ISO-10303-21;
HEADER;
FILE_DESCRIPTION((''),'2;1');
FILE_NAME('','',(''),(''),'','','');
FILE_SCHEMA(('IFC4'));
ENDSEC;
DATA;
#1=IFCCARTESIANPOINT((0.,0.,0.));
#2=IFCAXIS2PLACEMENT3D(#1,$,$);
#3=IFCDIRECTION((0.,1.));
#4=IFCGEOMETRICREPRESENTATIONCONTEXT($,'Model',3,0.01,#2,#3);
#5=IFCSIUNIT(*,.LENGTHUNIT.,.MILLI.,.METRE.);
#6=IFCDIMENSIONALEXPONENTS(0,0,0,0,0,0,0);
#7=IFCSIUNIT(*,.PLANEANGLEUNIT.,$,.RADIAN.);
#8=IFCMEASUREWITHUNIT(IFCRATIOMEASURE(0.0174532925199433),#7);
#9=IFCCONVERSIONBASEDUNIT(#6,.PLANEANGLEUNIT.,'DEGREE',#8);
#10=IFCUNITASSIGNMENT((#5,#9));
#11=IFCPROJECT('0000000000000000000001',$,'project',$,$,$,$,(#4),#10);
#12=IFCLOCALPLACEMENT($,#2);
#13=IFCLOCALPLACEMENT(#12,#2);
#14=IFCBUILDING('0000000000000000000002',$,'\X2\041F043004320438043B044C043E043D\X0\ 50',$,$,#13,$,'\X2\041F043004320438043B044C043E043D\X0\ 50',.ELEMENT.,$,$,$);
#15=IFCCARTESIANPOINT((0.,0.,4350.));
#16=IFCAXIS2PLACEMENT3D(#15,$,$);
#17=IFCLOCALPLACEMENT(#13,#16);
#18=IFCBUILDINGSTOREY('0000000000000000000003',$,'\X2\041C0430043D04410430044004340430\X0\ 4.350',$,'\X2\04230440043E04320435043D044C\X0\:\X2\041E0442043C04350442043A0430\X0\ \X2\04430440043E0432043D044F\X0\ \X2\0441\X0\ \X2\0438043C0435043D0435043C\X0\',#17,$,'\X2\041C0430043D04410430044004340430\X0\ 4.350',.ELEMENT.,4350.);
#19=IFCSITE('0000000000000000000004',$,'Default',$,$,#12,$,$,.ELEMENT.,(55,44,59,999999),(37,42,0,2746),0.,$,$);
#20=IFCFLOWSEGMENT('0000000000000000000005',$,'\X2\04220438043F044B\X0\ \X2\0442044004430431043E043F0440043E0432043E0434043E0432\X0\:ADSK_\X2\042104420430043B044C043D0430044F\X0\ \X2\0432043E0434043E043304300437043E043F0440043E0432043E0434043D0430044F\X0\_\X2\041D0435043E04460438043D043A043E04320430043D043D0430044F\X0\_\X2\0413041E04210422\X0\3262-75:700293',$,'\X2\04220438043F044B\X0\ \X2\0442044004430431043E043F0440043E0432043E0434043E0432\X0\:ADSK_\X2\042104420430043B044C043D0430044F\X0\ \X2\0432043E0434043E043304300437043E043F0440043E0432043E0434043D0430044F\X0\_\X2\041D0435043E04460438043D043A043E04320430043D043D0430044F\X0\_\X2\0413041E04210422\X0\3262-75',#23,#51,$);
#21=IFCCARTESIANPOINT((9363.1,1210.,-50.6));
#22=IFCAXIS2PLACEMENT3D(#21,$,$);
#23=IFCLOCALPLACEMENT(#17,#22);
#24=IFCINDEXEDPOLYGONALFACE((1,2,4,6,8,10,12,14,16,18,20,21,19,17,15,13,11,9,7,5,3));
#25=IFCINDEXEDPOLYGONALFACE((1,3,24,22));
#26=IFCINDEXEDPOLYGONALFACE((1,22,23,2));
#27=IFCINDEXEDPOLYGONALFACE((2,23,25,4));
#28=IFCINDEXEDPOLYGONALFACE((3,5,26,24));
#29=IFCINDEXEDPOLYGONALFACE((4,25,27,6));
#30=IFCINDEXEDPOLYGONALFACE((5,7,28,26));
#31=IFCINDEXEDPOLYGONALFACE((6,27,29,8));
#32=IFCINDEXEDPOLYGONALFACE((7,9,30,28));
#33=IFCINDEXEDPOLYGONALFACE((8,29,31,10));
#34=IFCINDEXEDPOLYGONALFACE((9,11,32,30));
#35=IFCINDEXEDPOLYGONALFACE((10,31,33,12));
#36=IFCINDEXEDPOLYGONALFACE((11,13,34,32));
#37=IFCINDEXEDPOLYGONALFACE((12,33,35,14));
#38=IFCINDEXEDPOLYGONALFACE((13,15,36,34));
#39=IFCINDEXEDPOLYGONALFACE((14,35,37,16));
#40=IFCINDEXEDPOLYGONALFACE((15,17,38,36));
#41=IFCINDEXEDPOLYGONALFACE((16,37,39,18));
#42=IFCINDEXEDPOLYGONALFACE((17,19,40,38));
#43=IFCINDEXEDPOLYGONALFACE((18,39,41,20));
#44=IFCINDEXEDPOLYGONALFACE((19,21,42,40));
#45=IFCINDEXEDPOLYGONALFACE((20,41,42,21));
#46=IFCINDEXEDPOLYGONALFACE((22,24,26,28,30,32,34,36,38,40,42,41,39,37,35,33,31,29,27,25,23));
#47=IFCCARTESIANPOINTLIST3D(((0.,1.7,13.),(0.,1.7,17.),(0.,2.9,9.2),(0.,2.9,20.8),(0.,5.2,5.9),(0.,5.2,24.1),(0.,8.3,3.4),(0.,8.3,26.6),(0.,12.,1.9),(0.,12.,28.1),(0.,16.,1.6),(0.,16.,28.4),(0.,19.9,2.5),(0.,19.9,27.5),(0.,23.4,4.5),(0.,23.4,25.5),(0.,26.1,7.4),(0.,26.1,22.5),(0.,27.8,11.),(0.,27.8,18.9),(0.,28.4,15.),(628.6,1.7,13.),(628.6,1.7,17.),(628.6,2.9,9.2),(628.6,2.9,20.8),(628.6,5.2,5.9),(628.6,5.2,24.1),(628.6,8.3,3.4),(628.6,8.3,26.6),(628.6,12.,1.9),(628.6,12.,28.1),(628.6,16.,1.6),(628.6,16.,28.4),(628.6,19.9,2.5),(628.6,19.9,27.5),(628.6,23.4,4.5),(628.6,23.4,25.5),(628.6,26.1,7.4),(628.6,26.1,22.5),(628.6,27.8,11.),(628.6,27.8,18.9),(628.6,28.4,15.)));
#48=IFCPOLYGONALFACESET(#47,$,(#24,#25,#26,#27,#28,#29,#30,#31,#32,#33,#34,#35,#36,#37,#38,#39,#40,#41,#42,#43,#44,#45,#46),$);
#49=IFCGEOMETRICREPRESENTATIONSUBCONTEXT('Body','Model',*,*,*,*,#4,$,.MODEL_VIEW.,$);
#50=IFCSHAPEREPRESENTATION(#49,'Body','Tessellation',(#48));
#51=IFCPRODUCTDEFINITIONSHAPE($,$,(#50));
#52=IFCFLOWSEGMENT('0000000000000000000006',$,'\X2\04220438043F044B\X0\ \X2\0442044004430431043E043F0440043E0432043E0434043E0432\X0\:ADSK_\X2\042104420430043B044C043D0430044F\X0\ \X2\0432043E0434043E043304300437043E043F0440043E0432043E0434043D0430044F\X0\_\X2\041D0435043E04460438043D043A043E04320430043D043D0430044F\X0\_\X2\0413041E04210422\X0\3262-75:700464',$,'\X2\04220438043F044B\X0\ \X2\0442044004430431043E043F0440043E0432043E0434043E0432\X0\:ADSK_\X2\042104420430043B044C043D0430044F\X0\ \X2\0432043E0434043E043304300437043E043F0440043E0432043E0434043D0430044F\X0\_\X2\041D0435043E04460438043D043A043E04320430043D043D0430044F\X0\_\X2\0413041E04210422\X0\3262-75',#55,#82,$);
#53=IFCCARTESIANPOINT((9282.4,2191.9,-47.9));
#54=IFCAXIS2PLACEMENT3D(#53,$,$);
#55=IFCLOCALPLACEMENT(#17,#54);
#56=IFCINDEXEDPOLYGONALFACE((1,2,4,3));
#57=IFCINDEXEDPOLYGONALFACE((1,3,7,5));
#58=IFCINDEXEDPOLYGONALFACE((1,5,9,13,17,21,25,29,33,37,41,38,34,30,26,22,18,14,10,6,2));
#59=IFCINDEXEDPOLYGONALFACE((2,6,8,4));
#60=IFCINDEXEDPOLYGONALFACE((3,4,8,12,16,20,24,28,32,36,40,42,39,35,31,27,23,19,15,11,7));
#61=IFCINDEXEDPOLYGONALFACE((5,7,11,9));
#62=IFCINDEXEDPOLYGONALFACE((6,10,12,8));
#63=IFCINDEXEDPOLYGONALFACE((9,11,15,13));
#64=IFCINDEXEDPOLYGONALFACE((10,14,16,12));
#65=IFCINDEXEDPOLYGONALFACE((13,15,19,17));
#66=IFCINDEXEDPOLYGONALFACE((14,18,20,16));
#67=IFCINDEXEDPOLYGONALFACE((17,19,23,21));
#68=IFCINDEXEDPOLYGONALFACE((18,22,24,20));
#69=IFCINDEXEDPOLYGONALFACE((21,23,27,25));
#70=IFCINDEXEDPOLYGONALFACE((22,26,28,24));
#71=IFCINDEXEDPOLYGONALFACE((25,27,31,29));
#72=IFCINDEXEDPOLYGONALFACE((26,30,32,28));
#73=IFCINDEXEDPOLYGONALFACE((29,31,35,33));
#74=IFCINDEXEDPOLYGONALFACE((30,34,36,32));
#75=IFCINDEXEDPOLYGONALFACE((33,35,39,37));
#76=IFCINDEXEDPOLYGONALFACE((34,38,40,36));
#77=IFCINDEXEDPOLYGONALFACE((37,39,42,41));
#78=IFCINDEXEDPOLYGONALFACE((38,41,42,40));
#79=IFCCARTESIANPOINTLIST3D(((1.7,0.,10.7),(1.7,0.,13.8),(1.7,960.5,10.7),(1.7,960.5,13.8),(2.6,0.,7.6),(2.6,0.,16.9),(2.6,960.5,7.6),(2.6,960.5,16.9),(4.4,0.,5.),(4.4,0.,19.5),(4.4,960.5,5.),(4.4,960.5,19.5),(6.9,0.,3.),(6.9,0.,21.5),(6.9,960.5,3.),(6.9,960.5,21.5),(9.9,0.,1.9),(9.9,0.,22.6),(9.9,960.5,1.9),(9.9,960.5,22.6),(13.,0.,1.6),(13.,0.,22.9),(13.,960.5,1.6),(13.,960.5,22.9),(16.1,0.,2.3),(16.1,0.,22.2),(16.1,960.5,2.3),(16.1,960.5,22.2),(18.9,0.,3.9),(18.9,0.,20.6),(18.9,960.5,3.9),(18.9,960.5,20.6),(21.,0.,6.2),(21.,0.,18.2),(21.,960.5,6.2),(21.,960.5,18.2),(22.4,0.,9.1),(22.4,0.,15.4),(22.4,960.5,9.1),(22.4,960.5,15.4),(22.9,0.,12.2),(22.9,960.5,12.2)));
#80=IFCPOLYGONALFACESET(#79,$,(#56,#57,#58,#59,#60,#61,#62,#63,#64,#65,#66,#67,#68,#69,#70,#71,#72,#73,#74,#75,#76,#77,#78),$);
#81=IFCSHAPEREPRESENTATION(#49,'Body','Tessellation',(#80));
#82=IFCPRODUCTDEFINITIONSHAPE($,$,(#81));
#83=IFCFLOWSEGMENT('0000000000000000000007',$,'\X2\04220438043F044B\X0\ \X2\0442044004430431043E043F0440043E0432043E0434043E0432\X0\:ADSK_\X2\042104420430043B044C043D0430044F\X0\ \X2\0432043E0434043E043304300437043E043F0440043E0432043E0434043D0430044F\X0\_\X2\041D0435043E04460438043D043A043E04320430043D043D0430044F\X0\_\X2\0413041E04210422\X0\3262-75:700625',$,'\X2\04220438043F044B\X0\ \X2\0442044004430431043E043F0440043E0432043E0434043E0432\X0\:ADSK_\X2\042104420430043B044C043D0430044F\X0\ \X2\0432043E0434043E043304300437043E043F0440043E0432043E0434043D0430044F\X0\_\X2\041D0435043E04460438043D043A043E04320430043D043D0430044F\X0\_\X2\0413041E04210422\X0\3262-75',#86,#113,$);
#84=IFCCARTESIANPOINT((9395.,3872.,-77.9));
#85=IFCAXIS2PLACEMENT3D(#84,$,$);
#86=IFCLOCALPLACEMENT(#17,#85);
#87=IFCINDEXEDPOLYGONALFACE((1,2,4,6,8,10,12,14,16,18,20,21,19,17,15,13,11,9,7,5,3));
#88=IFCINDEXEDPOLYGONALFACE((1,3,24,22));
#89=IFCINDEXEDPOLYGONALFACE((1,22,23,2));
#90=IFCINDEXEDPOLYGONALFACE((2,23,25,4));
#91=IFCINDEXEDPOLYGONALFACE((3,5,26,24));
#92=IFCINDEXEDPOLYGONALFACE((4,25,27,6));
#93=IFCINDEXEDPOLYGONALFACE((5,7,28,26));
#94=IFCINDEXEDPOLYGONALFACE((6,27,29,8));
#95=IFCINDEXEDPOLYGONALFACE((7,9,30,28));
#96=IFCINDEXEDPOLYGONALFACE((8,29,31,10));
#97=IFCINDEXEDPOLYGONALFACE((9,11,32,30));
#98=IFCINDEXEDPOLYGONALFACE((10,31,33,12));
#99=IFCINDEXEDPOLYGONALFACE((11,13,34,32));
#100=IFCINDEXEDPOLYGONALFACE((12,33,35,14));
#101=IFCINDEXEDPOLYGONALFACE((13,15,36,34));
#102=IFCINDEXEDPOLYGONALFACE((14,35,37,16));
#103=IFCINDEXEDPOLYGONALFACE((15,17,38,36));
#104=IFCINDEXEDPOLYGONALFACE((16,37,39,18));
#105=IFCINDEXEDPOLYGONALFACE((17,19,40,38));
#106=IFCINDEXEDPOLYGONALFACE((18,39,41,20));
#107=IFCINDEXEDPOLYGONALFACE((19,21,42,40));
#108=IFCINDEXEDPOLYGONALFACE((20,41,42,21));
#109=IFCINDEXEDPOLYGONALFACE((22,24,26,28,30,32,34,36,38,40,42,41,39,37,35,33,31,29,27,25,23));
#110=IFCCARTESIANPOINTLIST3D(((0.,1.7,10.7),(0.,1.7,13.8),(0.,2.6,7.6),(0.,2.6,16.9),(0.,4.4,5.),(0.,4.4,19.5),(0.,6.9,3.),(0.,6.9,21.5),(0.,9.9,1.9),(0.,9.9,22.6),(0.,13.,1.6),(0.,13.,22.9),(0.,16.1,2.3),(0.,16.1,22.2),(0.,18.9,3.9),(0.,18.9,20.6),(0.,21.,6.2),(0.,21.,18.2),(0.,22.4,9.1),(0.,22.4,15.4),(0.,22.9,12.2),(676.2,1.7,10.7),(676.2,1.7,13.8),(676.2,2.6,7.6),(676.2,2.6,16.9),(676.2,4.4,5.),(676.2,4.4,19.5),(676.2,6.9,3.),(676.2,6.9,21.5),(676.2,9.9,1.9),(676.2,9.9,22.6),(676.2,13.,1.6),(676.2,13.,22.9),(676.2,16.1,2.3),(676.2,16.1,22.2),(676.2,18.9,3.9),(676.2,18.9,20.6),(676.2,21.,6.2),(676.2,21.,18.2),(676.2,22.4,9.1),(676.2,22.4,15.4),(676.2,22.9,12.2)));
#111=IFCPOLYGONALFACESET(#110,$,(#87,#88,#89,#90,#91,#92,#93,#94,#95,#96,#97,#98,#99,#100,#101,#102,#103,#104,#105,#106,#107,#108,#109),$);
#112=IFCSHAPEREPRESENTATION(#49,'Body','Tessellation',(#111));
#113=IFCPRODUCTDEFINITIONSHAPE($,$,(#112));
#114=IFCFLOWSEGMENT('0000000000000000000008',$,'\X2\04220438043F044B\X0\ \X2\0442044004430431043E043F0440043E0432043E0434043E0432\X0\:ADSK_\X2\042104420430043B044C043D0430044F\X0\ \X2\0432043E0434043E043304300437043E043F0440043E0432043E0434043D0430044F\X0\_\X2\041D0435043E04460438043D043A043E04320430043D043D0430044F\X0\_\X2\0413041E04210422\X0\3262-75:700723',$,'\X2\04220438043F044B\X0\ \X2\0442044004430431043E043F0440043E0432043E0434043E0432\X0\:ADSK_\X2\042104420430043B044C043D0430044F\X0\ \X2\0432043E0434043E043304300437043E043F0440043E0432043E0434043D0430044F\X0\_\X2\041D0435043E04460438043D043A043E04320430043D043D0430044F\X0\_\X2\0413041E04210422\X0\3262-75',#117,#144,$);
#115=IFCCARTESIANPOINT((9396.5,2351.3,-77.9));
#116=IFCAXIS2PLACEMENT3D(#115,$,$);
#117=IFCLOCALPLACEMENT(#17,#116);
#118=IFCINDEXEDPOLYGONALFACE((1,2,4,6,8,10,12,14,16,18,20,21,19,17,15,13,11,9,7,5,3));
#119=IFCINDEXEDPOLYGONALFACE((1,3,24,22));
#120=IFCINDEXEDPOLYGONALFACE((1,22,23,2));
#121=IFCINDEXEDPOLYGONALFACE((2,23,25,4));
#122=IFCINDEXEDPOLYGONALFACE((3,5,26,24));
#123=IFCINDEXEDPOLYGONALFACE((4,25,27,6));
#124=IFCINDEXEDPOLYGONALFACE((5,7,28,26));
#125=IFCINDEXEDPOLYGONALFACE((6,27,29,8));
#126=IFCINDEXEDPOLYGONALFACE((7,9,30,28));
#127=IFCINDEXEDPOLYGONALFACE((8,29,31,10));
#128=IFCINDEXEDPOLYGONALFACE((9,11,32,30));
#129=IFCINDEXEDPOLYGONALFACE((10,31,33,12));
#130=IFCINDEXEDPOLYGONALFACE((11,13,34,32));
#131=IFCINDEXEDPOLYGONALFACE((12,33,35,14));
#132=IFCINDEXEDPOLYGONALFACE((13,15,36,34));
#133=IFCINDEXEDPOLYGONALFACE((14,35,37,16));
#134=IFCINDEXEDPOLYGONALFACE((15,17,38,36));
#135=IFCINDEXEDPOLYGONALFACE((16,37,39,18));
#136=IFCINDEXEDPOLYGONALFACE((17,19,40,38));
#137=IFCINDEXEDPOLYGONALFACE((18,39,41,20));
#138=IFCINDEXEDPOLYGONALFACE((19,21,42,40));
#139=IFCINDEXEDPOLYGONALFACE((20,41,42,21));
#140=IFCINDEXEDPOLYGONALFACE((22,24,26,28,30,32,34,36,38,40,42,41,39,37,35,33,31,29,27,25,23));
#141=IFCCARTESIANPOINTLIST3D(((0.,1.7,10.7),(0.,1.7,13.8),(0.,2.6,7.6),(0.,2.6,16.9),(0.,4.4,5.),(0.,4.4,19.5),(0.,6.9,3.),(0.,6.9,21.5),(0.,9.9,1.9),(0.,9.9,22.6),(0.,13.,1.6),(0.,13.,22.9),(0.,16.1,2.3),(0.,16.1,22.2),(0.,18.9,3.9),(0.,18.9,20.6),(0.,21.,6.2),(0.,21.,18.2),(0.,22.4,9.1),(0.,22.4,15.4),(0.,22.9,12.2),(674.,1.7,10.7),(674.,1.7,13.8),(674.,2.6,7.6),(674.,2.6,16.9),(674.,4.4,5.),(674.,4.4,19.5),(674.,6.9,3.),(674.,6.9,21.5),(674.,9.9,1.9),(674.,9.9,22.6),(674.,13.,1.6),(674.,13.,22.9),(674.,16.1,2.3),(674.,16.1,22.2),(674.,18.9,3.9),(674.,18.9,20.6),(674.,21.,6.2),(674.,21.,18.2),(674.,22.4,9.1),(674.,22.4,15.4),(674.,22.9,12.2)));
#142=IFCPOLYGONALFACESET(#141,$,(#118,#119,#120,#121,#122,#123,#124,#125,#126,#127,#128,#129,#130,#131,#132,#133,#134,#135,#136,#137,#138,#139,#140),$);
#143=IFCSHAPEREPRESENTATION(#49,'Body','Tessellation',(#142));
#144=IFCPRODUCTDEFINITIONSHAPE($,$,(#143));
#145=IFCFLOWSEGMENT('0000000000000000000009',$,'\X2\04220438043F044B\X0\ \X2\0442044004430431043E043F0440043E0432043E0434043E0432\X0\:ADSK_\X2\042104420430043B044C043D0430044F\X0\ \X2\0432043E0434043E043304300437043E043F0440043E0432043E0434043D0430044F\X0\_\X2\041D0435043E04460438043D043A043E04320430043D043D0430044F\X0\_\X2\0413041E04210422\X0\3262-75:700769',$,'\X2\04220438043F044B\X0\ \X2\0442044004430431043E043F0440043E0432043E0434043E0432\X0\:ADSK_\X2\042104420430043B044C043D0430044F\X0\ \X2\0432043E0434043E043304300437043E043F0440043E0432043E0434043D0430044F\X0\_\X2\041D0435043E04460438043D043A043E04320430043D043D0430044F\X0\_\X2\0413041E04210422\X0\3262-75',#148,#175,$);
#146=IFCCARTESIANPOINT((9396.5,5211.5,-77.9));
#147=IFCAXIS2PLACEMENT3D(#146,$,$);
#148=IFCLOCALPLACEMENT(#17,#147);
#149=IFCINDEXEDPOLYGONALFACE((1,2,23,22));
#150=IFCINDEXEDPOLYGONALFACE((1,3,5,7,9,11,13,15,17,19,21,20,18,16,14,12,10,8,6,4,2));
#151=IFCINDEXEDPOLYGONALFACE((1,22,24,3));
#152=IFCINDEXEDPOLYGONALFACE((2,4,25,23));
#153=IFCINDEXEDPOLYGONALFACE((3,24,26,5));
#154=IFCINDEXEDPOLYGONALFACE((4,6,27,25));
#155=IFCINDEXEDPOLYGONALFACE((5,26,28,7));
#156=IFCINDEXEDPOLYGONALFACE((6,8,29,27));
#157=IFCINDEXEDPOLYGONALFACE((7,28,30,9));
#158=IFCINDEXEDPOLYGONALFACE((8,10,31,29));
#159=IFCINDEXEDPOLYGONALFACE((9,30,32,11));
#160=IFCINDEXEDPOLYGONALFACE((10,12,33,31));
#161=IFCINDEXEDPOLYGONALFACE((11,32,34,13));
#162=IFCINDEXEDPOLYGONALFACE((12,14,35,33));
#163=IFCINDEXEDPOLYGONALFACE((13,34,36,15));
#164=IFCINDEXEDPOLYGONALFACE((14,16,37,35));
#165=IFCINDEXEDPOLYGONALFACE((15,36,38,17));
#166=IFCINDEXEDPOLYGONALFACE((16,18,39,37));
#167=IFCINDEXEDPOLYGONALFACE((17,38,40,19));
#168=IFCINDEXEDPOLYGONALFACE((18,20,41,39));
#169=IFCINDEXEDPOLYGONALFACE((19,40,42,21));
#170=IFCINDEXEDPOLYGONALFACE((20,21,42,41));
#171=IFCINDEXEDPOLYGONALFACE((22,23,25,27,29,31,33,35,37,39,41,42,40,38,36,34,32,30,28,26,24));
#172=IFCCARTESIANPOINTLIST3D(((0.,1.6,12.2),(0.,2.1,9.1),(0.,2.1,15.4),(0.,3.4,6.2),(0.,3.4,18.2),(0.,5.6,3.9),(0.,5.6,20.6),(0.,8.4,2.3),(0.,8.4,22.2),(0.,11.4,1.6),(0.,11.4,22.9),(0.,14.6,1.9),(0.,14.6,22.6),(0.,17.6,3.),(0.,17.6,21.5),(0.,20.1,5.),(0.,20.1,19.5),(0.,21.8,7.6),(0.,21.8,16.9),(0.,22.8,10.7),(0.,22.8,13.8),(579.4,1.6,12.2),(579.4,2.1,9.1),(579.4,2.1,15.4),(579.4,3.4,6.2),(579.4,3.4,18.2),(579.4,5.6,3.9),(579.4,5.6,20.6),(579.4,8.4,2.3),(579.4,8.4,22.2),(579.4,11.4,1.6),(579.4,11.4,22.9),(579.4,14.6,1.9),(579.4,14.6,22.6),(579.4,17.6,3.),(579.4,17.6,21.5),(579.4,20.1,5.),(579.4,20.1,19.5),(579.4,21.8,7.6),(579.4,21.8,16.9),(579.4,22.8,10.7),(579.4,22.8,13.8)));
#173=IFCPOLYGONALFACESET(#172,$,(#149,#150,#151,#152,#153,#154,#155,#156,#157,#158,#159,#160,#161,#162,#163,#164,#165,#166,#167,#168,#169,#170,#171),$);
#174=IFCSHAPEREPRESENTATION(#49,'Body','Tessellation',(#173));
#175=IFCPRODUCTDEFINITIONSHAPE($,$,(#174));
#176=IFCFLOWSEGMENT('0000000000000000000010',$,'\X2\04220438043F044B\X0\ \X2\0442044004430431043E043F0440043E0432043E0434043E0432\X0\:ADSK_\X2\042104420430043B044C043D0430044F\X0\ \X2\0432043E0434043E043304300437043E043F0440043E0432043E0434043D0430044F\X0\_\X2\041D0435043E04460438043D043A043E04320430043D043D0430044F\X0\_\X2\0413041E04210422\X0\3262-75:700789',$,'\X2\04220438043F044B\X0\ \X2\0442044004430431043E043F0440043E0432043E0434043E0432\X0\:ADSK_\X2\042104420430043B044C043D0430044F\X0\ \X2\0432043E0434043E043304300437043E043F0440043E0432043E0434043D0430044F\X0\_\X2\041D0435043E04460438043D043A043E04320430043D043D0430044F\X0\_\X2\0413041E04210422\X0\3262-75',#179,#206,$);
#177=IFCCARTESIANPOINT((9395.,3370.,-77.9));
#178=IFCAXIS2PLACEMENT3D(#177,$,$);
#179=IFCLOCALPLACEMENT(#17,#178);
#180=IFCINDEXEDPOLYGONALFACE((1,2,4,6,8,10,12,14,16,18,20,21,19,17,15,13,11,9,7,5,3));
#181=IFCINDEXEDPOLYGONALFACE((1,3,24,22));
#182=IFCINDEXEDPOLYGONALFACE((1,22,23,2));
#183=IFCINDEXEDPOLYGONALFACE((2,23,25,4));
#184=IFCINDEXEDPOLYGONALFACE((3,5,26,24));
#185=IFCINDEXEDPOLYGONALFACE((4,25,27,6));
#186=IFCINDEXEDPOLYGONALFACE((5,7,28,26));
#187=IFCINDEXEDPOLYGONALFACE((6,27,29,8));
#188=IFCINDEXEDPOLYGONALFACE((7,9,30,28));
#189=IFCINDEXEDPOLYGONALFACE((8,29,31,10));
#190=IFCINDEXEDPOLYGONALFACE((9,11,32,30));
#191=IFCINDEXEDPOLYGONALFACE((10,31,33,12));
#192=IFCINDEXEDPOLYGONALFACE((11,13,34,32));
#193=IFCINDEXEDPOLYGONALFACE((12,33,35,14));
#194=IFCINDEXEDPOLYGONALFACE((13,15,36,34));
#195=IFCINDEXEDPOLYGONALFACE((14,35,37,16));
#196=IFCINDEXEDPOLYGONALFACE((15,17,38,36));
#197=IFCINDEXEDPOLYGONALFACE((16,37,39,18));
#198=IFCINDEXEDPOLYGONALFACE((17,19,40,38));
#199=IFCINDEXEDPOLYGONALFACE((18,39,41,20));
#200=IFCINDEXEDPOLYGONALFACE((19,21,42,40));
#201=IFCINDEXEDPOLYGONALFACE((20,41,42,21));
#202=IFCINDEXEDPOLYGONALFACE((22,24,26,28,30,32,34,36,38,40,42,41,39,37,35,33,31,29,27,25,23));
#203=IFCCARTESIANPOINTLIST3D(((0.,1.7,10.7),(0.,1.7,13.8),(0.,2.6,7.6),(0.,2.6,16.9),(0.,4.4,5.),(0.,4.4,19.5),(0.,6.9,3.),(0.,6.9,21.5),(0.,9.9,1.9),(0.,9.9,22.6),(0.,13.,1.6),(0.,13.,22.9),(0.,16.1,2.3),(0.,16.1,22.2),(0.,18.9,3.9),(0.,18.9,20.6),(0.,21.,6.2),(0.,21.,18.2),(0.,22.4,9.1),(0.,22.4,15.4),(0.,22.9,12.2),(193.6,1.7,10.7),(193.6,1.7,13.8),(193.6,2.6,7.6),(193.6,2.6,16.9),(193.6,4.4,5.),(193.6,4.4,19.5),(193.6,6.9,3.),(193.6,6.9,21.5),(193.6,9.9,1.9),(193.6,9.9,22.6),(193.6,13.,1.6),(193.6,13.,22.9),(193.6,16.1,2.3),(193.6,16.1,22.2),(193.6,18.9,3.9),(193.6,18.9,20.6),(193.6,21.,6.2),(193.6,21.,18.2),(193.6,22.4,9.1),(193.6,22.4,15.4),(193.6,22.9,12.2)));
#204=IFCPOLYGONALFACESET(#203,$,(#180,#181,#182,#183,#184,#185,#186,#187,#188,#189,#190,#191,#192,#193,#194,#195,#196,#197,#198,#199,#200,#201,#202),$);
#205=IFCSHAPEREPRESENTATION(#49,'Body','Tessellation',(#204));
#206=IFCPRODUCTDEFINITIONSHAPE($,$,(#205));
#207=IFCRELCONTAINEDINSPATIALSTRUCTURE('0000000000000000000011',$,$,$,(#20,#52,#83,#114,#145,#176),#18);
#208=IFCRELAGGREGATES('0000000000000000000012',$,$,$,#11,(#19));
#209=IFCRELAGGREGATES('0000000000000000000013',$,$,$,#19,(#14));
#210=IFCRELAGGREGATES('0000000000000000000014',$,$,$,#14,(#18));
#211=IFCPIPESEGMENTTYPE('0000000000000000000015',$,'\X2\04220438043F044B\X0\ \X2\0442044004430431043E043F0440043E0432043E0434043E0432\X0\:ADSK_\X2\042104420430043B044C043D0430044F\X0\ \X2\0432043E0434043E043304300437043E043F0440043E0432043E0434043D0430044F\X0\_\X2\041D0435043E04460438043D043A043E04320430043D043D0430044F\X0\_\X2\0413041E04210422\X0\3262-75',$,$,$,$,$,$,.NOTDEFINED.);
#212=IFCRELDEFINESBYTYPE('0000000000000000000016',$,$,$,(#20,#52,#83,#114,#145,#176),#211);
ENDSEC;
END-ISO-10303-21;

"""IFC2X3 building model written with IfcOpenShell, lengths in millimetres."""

from ifc_helpers import new_model, entity, si_unit, converted_unit, direction, frame, origin, origin_2d_with_axis, place, context, subcontext, project, spatial, circle, extrude, type_object, element, save


model = new_model("IFC2X3")

# Units and contexts
model_context = context("Model", 3, precision=0.01, world=origin(), true_north=direction((0.0, 1.0)))
body_context = subcontext(model_context, "Body", "Model", "MODEL_VIEW")
ifc_project = project(units=[si_unit("LENGTHUNIT", "METRE", prefix="MILLI"), converted_unit("PLANEANGLEUNIT", "DEGREE", entity("IfcRatioMeasure", 0.0174532925199433), si_unit("PLANEANGLEUNIT", "RADIAN"), dimensions=[0, 0, 0, 0, 0, 0, 0])], contexts=[model_context])

# Site, building, storey
site_placement = place(None, origin())
site = spatial("IfcSite", under=ifc_project, at=site_placement, Name="Default", CompositionType="ELEMENT", RefLatitude=(55, 44, 59, 999999), RefLongitude=(37, 42, 0, 2746), RefElevation=0.0)
building_placement = place(site_placement, origin())
building = spatial("IfcBuilding", under=site, at=building_placement, Name="Павильон 50", LongName="Павильон 50", CompositionType="ELEMENT")
storey_placement = place(building_placement, frame((0.0, 0.0, 4350.0)))
storey = spatial("IfcBuildingStorey", under=building, at=storey_placement, Name="Мансарда 4.350", ObjectType="Уровень:Отметка уровня с именем", LongName="Мансарда 4.350", CompositionType="ELEMENT", Elevation=4350.0)

# Flow segments
pipe_segment_type = type_object("IfcPipeSegmentType", Name="Типы трубопроводов:ADSK_Стальная водогазопроводная_Неоцинкованная_ГОСТ3262-75", PredefinedType="NOTDEFINED")
flow_segment_1_placement = place(storey_placement, frame((9363.1, 1210.0, -50.6)))
element("IfcFlowSegment", 1, at=flow_segment_1_placement, inside=storey, type_object=pipe_segment_type, Name="Типы трубопроводов:ADSK_Стальная водогазопроводная_Неоцинкованная_ГОСТ3262-75:700293", ObjectType="Типы трубопроводов:ADSK_Стальная водогазопроводная_Неоцинкованная_ГОСТ3262-75", context=body_context, shape_type="SweptSolid", body=[
    extrude(circle(Radius=13.4, at=origin_2d_with_axis()), frame((0.0, 15.0, 15.0), z_axis=(1.0, 0.0, 0.0), x_axis=(0.0, 1.0, 0.0)), (0.0, 0.0, 1.0), 628.6),
])
flow_segment_2_placement = place(storey_placement, frame((9282.4, 2191.9, -47.9)))
element("IfcFlowSegment", 2, at=flow_segment_2_placement, inside=storey, type_object=pipe_segment_type, Name="Типы трубопроводов:ADSK_Стальная водогазопроводная_Неоцинкованная_ГОСТ3262-75:700464", ObjectType="Типы трубопроводов:ADSK_Стальная водогазопроводная_Неоцинкованная_ГОСТ3262-75", context=body_context, shape_type="SweptSolid", body=[
    extrude(circle(Radius=10.7, at=origin_2d_with_axis()), frame((12.2, 0.0, 12.2), z_axis=(0.0, 1.0, 0.0), x_axis=(1.0, 0.0, 0.0)), (0.0, 0.0, 1.0), 960.5),
])
flow_segment_3_placement = place(storey_placement, frame((9395.0, 3872.0, -77.9)))
element("IfcFlowSegment", 3, at=flow_segment_3_placement, inside=storey, type_object=pipe_segment_type, Name="Типы трубопроводов:ADSK_Стальная водогазопроводная_Неоцинкованная_ГОСТ3262-75:700625", ObjectType="Типы трубопроводов:ADSK_Стальная водогазопроводная_Неоцинкованная_ГОСТ3262-75", context=body_context, shape_type="SweptSolid", body=[
    extrude(circle(Radius=10.7, at=origin_2d_with_axis()), frame((0.0, 12.2, 12.2), z_axis=(1.0, 0.0, 0.0), x_axis=(0.0, 1.0, 0.0)), (0.0, 0.0, 1.0), 676.2),
])
flow_segment_4_placement = place(storey_placement, frame((9396.5, 2351.3, -77.9)))
element("IfcFlowSegment", 4, at=flow_segment_4_placement, inside=storey, type_object=pipe_segment_type, Name="Типы трубопроводов:ADSK_Стальная водогазопроводная_Неоцинкованная_ГОСТ3262-75:700723", ObjectType="Типы трубопроводов:ADSK_Стальная водогазопроводная_Неоцинкованная_ГОСТ3262-75", context=body_context, shape_type="SweptSolid", body=[
    extrude(circle(Radius=10.7, at=origin_2d_with_axis()), frame((0.0, 12.2, 12.2), z_axis=(1.0, 0.0, 0.0), x_axis=(0.0, 1.0, 0.0)), (0.0, 0.0, 1.0), 674.0),
])
flow_segment_5_placement = place(storey_placement, frame((9396.5, 5211.5, -77.9)))
element("IfcFlowSegment", 5, at=flow_segment_5_placement, inside=storey, type_object=pipe_segment_type, Name="Типы трубопроводов:ADSK_Стальная водогазопроводная_Неоцинкованная_ГОСТ3262-75:700769", ObjectType="Типы трубопроводов:ADSK_Стальная водогазопроводная_Неоцинкованная_ГОСТ3262-75", context=body_context, shape_type="SweptSolid", body=[
    extrude(circle(Radius=10.7, at=origin_2d_with_axis()), frame((0.0, 12.2, 12.2), z_axis=(1.0, 0.0, 0.0), x_axis=(0.0, -1.0, 0.0)), (0.0, 0.0, 1.0), 579.4),
])
flow_segment_6_placement = place(storey_placement, frame((9395.0, 3370.0, -77.9)))
element("IfcFlowSegment", 6, at=flow_segment_6_placement, inside=storey, type_object=pipe_segment_type, Name="Типы трубопроводов:ADSK_Стальная водогазопроводная_Неоцинкованная_ГОСТ3262-75:700789", ObjectType="Типы трубопроводов:ADSK_Стальная водогазопроводная_Неоцинкованная_ГОСТ3262-75", context=body_context, shape_type="SweptSolid", body=[
    extrude(circle(Radius=10.7, at=origin_2d_with_axis()), frame((0.0, 12.2, 12.2), z_axis=(1.0, 0.0, 0.0), x_axis=(0.0, 1.0, 0.0)), (0.0, 0.0, 1.0), 193.6),
])

save(model, "model.ifc")
